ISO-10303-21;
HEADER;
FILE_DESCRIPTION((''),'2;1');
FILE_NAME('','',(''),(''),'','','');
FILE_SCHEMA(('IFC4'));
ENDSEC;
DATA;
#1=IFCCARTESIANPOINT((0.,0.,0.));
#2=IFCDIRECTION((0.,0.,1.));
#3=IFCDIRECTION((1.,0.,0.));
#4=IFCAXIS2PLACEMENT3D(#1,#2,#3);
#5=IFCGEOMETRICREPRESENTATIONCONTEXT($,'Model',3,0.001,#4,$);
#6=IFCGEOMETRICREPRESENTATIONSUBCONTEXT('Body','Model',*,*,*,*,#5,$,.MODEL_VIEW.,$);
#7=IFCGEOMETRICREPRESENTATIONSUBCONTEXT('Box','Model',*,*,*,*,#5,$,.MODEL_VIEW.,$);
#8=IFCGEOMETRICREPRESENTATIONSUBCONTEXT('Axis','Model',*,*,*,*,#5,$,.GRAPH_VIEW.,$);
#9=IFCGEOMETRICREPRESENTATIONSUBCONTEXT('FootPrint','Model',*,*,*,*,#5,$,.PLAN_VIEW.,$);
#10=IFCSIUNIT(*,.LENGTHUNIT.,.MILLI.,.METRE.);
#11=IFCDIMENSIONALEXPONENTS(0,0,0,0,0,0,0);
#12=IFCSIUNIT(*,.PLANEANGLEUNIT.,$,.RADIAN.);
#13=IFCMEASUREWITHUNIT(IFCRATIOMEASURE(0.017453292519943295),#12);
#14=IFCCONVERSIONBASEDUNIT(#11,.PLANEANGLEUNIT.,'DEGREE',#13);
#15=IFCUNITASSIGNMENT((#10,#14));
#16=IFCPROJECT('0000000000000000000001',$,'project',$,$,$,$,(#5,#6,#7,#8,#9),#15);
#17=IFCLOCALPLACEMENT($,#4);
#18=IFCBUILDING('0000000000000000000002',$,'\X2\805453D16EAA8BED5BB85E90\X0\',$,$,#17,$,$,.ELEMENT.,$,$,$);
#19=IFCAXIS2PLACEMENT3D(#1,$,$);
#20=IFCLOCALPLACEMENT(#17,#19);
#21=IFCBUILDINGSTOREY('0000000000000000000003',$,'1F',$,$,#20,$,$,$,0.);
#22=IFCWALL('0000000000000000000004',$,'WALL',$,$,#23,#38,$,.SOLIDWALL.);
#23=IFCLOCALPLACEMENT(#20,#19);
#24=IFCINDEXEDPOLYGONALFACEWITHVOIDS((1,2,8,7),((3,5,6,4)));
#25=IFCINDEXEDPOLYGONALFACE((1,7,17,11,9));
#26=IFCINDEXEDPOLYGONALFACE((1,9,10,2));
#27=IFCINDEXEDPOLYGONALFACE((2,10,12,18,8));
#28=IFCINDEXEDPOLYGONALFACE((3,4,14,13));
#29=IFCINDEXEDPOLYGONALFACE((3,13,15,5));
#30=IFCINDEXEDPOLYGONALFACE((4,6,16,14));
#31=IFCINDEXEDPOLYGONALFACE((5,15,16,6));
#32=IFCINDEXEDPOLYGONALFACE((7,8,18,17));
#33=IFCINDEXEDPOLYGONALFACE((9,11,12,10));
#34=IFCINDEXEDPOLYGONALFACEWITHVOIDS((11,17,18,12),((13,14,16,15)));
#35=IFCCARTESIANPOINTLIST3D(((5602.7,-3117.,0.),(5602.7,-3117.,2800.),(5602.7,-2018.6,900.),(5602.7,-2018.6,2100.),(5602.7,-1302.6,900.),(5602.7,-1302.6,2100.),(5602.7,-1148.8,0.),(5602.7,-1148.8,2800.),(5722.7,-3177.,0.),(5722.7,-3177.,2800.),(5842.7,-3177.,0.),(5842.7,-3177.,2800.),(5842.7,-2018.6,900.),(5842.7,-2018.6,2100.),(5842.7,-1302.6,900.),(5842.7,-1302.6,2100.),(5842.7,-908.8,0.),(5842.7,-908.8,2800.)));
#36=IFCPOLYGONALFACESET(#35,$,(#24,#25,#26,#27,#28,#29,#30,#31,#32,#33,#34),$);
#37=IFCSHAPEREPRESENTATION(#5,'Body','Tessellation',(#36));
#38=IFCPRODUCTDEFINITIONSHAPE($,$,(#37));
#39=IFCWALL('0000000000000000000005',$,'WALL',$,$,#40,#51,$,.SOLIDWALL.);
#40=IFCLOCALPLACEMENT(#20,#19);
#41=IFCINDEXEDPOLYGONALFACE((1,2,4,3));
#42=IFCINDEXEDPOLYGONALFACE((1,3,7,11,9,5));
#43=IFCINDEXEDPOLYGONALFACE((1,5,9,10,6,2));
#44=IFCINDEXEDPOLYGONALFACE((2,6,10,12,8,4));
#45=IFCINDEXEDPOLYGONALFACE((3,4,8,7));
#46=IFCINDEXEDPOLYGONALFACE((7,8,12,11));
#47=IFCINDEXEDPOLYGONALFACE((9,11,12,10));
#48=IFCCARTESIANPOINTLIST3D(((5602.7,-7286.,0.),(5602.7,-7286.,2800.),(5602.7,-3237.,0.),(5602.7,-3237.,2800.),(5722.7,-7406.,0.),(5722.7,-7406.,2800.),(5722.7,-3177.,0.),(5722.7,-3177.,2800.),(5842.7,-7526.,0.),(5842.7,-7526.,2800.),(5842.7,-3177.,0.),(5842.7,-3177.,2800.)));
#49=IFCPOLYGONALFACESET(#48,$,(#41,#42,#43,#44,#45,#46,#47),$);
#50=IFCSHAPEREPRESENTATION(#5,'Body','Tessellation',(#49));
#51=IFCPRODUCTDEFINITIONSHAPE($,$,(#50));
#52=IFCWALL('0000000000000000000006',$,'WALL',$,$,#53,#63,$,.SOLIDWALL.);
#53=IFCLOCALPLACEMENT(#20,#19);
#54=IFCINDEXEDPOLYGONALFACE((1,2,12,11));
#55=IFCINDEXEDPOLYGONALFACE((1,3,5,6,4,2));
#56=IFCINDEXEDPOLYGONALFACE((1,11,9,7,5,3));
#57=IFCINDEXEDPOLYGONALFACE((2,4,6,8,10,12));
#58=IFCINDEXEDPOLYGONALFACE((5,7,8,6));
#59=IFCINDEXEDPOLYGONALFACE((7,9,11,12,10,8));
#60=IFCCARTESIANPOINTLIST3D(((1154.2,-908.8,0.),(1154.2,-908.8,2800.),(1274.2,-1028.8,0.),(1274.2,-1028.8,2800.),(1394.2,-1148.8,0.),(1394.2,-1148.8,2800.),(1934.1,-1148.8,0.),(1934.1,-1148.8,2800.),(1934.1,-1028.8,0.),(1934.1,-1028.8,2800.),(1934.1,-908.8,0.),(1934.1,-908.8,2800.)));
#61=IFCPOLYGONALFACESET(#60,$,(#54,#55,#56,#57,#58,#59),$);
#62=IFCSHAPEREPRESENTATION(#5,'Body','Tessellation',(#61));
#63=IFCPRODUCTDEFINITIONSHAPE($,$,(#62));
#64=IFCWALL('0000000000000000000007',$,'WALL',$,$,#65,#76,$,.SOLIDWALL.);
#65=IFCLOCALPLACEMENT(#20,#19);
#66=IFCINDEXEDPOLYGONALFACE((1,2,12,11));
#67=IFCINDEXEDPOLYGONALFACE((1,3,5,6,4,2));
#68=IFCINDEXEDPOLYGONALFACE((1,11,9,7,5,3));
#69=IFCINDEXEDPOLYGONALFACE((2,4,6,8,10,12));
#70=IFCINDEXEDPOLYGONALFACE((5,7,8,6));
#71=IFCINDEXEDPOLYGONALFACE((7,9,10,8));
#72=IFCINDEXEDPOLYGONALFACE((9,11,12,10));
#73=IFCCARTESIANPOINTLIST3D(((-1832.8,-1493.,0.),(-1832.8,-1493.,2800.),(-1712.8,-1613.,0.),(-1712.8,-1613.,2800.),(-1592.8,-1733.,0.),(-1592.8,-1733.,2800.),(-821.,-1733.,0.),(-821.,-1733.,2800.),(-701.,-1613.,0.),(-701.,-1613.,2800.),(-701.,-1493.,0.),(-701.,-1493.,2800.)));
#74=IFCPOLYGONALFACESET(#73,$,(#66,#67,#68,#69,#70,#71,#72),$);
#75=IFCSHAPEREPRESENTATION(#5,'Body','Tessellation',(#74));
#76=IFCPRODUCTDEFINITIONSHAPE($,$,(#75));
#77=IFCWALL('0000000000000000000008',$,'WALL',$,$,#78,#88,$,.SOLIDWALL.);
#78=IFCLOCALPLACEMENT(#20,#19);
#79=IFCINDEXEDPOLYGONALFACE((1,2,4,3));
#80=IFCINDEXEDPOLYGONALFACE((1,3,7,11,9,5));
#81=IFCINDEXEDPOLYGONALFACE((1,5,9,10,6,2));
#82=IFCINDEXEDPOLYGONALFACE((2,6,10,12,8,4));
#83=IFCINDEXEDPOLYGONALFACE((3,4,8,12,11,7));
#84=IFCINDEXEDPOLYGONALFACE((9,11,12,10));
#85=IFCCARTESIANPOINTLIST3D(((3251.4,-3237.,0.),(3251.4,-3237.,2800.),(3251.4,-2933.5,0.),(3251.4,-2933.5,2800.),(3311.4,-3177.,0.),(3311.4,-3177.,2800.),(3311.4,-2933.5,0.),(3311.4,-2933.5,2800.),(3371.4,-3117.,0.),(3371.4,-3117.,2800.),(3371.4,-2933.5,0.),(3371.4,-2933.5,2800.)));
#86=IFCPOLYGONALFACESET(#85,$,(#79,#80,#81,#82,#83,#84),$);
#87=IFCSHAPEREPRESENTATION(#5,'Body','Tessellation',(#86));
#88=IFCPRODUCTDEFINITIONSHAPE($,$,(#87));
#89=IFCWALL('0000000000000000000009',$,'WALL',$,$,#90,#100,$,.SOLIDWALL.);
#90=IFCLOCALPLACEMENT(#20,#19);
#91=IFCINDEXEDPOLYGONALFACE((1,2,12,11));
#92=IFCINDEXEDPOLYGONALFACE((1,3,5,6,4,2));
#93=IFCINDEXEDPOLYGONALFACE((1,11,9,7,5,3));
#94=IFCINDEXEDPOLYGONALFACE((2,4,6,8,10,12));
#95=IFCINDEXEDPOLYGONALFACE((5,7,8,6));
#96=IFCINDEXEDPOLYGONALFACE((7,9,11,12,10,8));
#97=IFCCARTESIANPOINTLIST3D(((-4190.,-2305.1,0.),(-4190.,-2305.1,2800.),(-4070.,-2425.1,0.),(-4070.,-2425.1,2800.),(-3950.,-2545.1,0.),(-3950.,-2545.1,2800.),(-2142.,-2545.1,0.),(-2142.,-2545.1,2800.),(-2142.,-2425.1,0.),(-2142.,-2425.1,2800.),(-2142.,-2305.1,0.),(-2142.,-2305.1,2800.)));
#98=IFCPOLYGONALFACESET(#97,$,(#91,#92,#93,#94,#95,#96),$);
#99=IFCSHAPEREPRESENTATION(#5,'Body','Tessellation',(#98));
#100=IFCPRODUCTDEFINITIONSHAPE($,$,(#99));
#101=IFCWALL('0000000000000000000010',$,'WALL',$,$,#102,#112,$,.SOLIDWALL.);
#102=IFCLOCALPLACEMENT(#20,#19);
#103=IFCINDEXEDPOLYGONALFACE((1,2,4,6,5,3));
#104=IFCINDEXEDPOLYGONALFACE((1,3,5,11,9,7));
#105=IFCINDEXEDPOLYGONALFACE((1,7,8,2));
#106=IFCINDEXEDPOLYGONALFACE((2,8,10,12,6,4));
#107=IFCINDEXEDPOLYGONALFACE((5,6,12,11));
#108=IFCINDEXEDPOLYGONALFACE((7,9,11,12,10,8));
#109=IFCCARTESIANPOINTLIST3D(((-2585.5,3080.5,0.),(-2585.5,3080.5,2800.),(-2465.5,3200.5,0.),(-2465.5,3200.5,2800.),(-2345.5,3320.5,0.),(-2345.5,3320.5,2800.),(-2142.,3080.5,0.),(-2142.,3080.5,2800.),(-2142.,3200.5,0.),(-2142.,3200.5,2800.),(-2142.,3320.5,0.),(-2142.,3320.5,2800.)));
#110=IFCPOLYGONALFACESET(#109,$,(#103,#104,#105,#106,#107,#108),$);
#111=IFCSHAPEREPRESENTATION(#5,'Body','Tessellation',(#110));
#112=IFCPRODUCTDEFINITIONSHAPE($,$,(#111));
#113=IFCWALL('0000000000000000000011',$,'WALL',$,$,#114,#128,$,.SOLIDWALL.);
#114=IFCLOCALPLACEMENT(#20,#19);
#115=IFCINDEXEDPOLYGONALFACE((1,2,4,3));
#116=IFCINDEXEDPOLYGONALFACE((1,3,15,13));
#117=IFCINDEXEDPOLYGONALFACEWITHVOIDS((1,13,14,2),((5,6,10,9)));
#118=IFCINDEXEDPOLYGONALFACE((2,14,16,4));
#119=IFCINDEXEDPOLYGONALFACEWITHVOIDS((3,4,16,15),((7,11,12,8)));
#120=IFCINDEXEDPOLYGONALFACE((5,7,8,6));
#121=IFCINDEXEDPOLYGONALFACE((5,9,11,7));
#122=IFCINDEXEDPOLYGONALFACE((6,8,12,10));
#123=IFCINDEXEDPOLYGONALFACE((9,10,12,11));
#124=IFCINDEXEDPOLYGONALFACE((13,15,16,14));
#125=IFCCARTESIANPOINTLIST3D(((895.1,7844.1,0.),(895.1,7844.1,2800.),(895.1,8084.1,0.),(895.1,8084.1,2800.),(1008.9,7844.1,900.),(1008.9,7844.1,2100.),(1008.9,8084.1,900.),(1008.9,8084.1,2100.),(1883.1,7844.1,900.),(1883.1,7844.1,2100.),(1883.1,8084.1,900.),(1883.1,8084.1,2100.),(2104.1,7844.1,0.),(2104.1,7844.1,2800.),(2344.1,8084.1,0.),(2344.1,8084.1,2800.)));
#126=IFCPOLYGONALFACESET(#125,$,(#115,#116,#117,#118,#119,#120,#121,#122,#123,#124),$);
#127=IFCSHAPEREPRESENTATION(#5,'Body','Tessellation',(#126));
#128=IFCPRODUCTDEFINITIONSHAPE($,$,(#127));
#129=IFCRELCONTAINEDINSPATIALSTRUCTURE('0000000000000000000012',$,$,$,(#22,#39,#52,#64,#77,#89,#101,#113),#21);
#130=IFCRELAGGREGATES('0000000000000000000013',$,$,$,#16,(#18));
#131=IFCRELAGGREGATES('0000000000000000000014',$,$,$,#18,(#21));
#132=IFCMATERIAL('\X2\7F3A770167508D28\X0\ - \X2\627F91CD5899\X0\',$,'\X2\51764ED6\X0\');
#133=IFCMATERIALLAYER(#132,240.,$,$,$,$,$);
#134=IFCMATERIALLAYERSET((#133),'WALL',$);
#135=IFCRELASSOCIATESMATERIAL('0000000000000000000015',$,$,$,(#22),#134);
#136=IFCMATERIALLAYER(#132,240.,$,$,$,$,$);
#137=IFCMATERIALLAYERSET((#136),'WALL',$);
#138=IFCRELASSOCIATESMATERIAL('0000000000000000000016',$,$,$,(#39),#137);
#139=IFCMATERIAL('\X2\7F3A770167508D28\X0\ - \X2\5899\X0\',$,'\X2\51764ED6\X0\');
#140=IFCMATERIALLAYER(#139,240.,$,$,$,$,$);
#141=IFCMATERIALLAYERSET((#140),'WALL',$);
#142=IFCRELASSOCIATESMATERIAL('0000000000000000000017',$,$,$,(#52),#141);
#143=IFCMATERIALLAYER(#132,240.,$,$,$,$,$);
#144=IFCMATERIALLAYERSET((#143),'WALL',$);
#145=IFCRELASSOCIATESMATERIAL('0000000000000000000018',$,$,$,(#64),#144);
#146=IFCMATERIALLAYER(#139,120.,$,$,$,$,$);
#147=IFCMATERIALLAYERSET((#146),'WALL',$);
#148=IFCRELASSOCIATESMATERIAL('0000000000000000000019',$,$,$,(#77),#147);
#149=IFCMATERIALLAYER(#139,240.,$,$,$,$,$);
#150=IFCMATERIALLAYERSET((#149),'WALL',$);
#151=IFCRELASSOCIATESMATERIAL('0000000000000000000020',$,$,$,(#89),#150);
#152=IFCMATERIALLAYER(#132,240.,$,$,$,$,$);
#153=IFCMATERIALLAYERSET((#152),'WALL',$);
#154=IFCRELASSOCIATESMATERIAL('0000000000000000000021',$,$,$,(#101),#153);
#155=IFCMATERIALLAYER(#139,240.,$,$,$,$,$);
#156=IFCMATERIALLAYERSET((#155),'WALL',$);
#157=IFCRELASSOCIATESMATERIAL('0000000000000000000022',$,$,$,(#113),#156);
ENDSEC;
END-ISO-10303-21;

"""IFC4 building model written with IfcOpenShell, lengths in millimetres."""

from ifc_helpers import new_model, entity, si_unit, converted_unit, frame, origin, origin_with_axes, place, context, subcontext, project, spatial, polyline, segment, composite_curve, outline, extrude, material, layer, layer_set, layer_usage, element, save


model = new_model("IFC4")

# Units and contexts
model_context = context("Model", 3, precision=0.001, world=origin_with_axes())
body_context = subcontext(model_context, "Body", "Model", "MODEL_VIEW")
box_context = subcontext(model_context, "Box", "Model", "MODEL_VIEW")
axis_context = subcontext(model_context, "Axis", "Model", "GRAPH_VIEW")
footprint_context = subcontext(model_context, "FootPrint", "Model", "PLAN_VIEW")
ifc_project = project(units=[si_unit("LENGTHUNIT", "METRE", prefix="MILLI"), converted_unit("PLANEANGLEUNIT", "DEGREE", entity("IfcRatioMeasure", 0.017453292519943295), si_unit("PLANEANGLEUNIT", "RADIAN"), dimensions=[0, 0, 0, 0, 0, 0, 0])], contexts=[model_context, body_context, box_context, axis_context, footprint_context])

# Building, storey
building_placement = place(None, origin_with_axes())
building = spatial("IfcBuilding", under=ifc_project, at=building_placement, Name="联发溪语宸庐", CompositionType="ELEMENT")
storey_placement = place(building_placement, origin())
storey = spatial("IfcBuildingStorey", under=building, at=storey_placement, Name="1F", Elevation=0.0)

# Shared definitions
ifc_material_1 = material(Name="缺省材质 - 墙", Category="其他")

# Shared definitions
ifc_material_2 = material(Name="缺省材质 - 承重墙", Category="其他")

# Wall, opening
ifc_layer_1 = layer(ifc_material_2, 240.0)
ifc_layer_set_1 = layer_set([ifc_layer_1], Name="WALL")
ifc_layer_usage_1 = layer_usage(ifc_layer_set_1, "AXIS2", "NEGATIVE", 120.0)
wall_1_placement = place(None, origin_with_axes())
wall_1 = element("IfcWall", 1, at=wall_1_placement, inside=storey, material=ifc_layer_usage_1, Name="WALL", PredefinedType="SOLIDWALL", context=model_context, shape_type="SweptSolid", body=[
    extrude(outline(composite_curve([segment(polyline([(5722.7, -3177.0), (5842.7, -3177.0)]), True, "CONTINUOUS"), segment(polyline([(5842.7, -3177.0), (5842.7, -908.8)]), True, "CONTINUOUS"), segment(polyline([(5842.7, -908.8), (5722.7, -1028.8)]), True, "CONTINUOUS"), segment(polyline([(5722.7, -1028.8), (5602.7, -1148.8)]), True, "CONTINUOUS"), segment(polyline([(5602.7, -1148.8), (5602.7, -3117.0)]), True, "CONTINUOUS"), segment(polyline([(5602.7, -3117.0), (5722.7, -3177.0)]), True, "CONTINUOUS")], self_intersect=False)), origin(), (0.0, 0.0, 1.0), 2800.0),
])
opening_1_placement = place(None, origin_with_axes())
element("IfcOpeningElement", 2, at=opening_1_placement, cuts=wall_1, ObjectType="OPENING", PredefinedType="OPENING", context=model_context, shape_type="SweptSolid", body=[
    extrude(outline(composite_curve([segment(polyline([(5602.7, -1302.6), (5602.7, -2018.6)]), True, "CONTINUOUS"), segment(polyline([(5602.7, -2018.6), (5842.7, -2018.6)]), True, "CONTINUOUS"), segment(polyline([(5842.7, -2018.6), (5842.7, -1302.6)]), True, "CONTINUOUS"), segment(polyline([(5842.7, -1302.6), (5602.7, -1302.6)]), True, "CONTINUOUS")], self_intersect=False)), frame((0.0, 0.0, 900.0), z_axis=(0.0, 0.0, 1.0), x_axis=(1.0, 0.0, 0.0)), (0.0, 0.0, 1.0), 1200.0),
])

# Walls
ifc_layer_2 = layer(ifc_material_2, 240.0)
ifc_layer_set_2 = layer_set([ifc_layer_2], Name="WALL")
ifc_layer_usage_2 = layer_usage(ifc_layer_set_2, "AXIS2", "NEGATIVE", 120.0)
wall_2_placement = place(None, origin_with_axes())
element("IfcWall", 3, at=wall_2_placement, inside=storey, material=ifc_layer_usage_2, Name="WALL", PredefinedType="SOLIDWALL", context=model_context, shape_type="SweptSolid", body=[
    extrude(outline(composite_curve([segment(polyline([(5722.7, -7406.0), (5842.7, -7526.0)]), True, "CONTINUOUS"), segment(polyline([(5842.7, -7526.0), (5842.7, -3177.0)]), True, "CONTINUOUS"), segment(polyline([(5842.7, -3177.0), (5722.7, -3177.0)]), True, "CONTINUOUS"), segment(polyline([(5722.7, -3177.0), (5602.7, -3237.0)]), True, "CONTINUOUS"), segment(polyline([(5602.7, -3237.0), (5602.7, -7286.0)]), True, "CONTINUOUS"), segment(polyline([(5602.7, -7286.0), (5722.7, -7406.0)]), True, "CONTINUOUS")], self_intersect=False)), origin(), (0.0, 0.0, 1.0), 2800.0),
])
ifc_layer_3 = layer(ifc_material_1, 240.0)
ifc_layer_set_3 = layer_set([ifc_layer_3], Name="WALL")
ifc_layer_usage_3 = layer_usage(ifc_layer_set_3, "AXIS2", "NEGATIVE", 120.0)
wall_3_placement = place(None, origin_with_axes())
element("IfcWall", 4, at=wall_3_placement, inside=storey, material=ifc_layer_usage_3, Name="WALL", PredefinedType="SOLIDWALL", context=model_context, shape_type="SweptSolid", body=[
    extrude(outline(composite_curve([segment(polyline([(1934.1, -1028.8), (1934.1, -908.8)]), True, "CONTINUOUS"), segment(polyline([(1934.1, -908.8), (1154.2, -908.8)]), True, "CONTINUOUS"), segment(polyline([(1154.2, -908.8), (1274.2, -1028.8)]), True, "CONTINUOUS"), segment(polyline([(1274.2, -1028.8), (1394.2, -1148.8)]), True, "CONTINUOUS"), segment(polyline([(1394.2, -1148.8), (1934.1, -1148.8)]), True, "CONTINUOUS"), segment(polyline([(1934.1, -1148.8), (1934.1, -1028.8)]), True, "CONTINUOUS")], self_intersect=False)), origin(), (0.0, 0.0, 1.0), 2800.0),
])
ifc_layer_4 = layer(ifc_material_2, 240.0)
ifc_layer_set_4 = layer_set([ifc_layer_4], Name="WALL")
ifc_layer_usage_4 = layer_usage(ifc_layer_set_4, "AXIS2", "NEGATIVE", 120.0)
wall_4_placement = place(None, origin_with_axes())
element("IfcWall", 5, at=wall_4_placement, inside=storey, material=ifc_layer_usage_4, Name="WALL", PredefinedType="SOLIDWALL", context=model_context, shape_type="SweptSolid", body=[
    extrude(outline(composite_curve([segment(polyline([(-1712.8, -1613.0), (-1592.8, -1733.0)]), True, "CONTINUOUS"), segment(polyline([(-1592.8, -1733.0), (-821.0, -1733.0)]), True, "CONTINUOUS"), segment(polyline([(-821.0, -1733.0), (-701.0, -1613.0)]), True, "CONTINUOUS"), segment(polyline([(-701.0, -1613.0), (-701.0, -1493.0)]), True, "CONTINUOUS"), segment(polyline([(-701.0, -1493.0), (-1832.8, -1493.0)]), True, "CONTINUOUS"), segment(polyline([(-1832.8, -1493.0), (-1712.8, -1613.0)]), True, "CONTINUOUS")], self_intersect=False)), origin(), (0.0, 0.0, 1.0), 2800.0),
])
ifc_layer_5 = layer(ifc_material_1, 120.0)
ifc_layer_set_5 = layer_set([ifc_layer_5], Name="WALL")
ifc_layer_usage_5 = layer_usage(ifc_layer_set_5, "AXIS2", "NEGATIVE", 60.0)
wall_5_placement = place(None, origin_with_axes())
element("IfcWall", 6, at=wall_5_placement, inside=storey, material=ifc_layer_usage_5, Name="WALL", PredefinedType="SOLIDWALL", context=model_context, shape_type="SweptSolid", body=[
    extrude(outline(composite_curve([segment(polyline([(3311.4, -2933.5), (3251.4, -2933.5)]), True, "CONTINUOUS"), segment(polyline([(3251.4, -2933.5), (3251.4, -3237.0)]), True, "CONTINUOUS"), segment(polyline([(3251.4, -3237.0), (3311.4, -3177.0)]), True, "CONTINUOUS"), segment(polyline([(3311.4, -3177.0), (3371.4, -3117.0)]), True, "CONTINUOUS"), segment(polyline([(3371.4, -3117.0), (3371.4, -2933.5)]), True, "CONTINUOUS"), segment(polyline([(3371.4, -2933.5), (3311.4, -2933.5)]), True, "CONTINUOUS")], self_intersect=False)), origin(), (0.0, 0.0, 1.0), 2800.0),
])
ifc_layer_6 = layer(ifc_material_1, 240.0)
ifc_layer_set_6 = layer_set([ifc_layer_6], Name="WALL")
ifc_layer_usage_6 = layer_usage(ifc_layer_set_6, "AXIS2", "NEGATIVE", 120.0)
wall_6_placement = place(None, origin_with_axes())
element("IfcWall", 7, at=wall_6_placement, inside=storey, material=ifc_layer_usage_6, Name="WALL", PredefinedType="SOLIDWALL", context=model_context, shape_type="SweptSolid", body=[
    extrude(outline(composite_curve([segment(polyline([(-4070.0, -2425.1), (-3950.0, -2545.1)]), True, "CONTINUOUS"), segment(polyline([(-3950.0, -2545.1), (-2142.0, -2545.1)]), True, "CONTINUOUS"), segment(polyline([(-2142.0, -2545.1), (-2142.0, -2425.1)]), True, "CONTINUOUS"), segment(polyline([(-2142.0, -2425.1), (-2142.0, -2305.1)]), True, "CONTINUOUS"), segment(polyline([(-2142.0, -2305.1), (-4190.0, -2305.1)]), True, "CONTINUOUS"), segment(polyline([(-4190.0, -2305.1), (-4070.0, -2425.1)]), True, "CONTINUOUS")], self_intersect=False)), origin(), (0.0, 0.0, 1.0), 2800.0),
])
ifc_layer_7 = layer(ifc_material_2, 240.0)
ifc_layer_set_7 = layer_set([ifc_layer_7], Name="WALL")
ifc_layer_usage_7 = layer_usage(ifc_layer_set_7, "AXIS2", "NEGATIVE", 120.0)
wall_7_placement = place(None, origin_with_axes())
element("IfcWall", 8, at=wall_7_placement, inside=storey, material=ifc_layer_usage_7, Name="WALL", PredefinedType="SOLIDWALL", context=model_context, shape_type="SweptSolid", body=[
    extrude(outline(composite_curve([segment(polyline([(-2142.0, 3200.5), (-2142.0, 3320.5)]), True, "CONTINUOUS"), segment(polyline([(-2142.0, 3320.5), (-2345.5, 3320.5)]), True, "CONTINUOUS"), segment(polyline([(-2345.5, 3320.5), (-2465.5, 3200.5)]), True, "CONTINUOUS"), segment(polyline([(-2465.5, 3200.5), (-2585.5, 3080.5)]), True, "CONTINUOUS"), segment(polyline([(-2585.5, 3080.5), (-2142.0, 3080.5)]), True, "CONTINUOUS"), segment(polyline([(-2142.0, 3080.5), (-2142.0, 3200.5)]), True, "CONTINUOUS")], self_intersect=False)), origin(), (0.0, 0.0, 1.0), 2800.0),
])

# Wall, opening
ifc_layer_8 = layer(ifc_material_1, 240.0)
ifc_layer_set_8 = layer_set([ifc_layer_8], Name="WALL")
ifc_layer_usage_8 = layer_usage(ifc_layer_set_8, "AXIS2", "NEGATIVE", 120.0)
wall_8_placement = place(None, origin_with_axes())
wall_8 = element("IfcWall", 9, at=wall_8_placement, inside=storey, material=ifc_layer_usage_8, Name="WALL", PredefinedType="SOLIDWALL", context=model_context, shape_type="SweptSolid", body=[
    extrude(outline(composite_curve([segment(polyline([(895.1, 7964.1), (895.1, 7844.1)]), True, "CONTINUOUS"), segment(polyline([(895.1, 7844.1), (2104.1, 7844.1)]), True, "CONTINUOUS"), segment(polyline([(2104.1, 7844.1), (2224.1, 7964.1)]), True, "CONTINUOUS"), segment(polyline([(2224.1, 7964.1), (2344.1, 8084.1)]), True, "CONTINUOUS"), segment(polyline([(2344.1, 8084.1), (895.1, 8084.1)]), True, "CONTINUOUS"), segment(polyline([(895.1, 8084.1), (895.1, 7964.1)]), True, "CONTINUOUS")], self_intersect=False)), origin(), (0.0, 0.0, 1.0), 2800.0),
])
opening_2_placement = place(None, origin_with_axes())
element("IfcOpeningElement", 10, at=opening_2_placement, cuts=wall_8, ObjectType="OPENING", PredefinedType="OPENING", context=model_context, shape_type="SweptSolid", body=[
    extrude(outline(composite_curve([segment(polyline([(1883.1, 8084.1), (1008.9, 8084.1)]), True, "CONTINUOUS"), segment(polyline([(1008.9, 8084.1), (1008.9, 7844.1)]), True, "CONTINUOUS"), segment(polyline([(1008.9, 7844.1), (1883.1, 7844.1)]), True, "CONTINUOUS"), segment(polyline([(1883.1, 7844.1), (1883.1, 8084.1)]), True, "CONTINUOUS")], self_intersect=False)), frame((0.0, 0.0, 900.0), z_axis=(0.0, 0.0, 1.0), x_axis=(1.0, 0.0, 0.0)), (0.0, 0.0, 1.0), 1200.0),
])

save(model, "model.ifc")
